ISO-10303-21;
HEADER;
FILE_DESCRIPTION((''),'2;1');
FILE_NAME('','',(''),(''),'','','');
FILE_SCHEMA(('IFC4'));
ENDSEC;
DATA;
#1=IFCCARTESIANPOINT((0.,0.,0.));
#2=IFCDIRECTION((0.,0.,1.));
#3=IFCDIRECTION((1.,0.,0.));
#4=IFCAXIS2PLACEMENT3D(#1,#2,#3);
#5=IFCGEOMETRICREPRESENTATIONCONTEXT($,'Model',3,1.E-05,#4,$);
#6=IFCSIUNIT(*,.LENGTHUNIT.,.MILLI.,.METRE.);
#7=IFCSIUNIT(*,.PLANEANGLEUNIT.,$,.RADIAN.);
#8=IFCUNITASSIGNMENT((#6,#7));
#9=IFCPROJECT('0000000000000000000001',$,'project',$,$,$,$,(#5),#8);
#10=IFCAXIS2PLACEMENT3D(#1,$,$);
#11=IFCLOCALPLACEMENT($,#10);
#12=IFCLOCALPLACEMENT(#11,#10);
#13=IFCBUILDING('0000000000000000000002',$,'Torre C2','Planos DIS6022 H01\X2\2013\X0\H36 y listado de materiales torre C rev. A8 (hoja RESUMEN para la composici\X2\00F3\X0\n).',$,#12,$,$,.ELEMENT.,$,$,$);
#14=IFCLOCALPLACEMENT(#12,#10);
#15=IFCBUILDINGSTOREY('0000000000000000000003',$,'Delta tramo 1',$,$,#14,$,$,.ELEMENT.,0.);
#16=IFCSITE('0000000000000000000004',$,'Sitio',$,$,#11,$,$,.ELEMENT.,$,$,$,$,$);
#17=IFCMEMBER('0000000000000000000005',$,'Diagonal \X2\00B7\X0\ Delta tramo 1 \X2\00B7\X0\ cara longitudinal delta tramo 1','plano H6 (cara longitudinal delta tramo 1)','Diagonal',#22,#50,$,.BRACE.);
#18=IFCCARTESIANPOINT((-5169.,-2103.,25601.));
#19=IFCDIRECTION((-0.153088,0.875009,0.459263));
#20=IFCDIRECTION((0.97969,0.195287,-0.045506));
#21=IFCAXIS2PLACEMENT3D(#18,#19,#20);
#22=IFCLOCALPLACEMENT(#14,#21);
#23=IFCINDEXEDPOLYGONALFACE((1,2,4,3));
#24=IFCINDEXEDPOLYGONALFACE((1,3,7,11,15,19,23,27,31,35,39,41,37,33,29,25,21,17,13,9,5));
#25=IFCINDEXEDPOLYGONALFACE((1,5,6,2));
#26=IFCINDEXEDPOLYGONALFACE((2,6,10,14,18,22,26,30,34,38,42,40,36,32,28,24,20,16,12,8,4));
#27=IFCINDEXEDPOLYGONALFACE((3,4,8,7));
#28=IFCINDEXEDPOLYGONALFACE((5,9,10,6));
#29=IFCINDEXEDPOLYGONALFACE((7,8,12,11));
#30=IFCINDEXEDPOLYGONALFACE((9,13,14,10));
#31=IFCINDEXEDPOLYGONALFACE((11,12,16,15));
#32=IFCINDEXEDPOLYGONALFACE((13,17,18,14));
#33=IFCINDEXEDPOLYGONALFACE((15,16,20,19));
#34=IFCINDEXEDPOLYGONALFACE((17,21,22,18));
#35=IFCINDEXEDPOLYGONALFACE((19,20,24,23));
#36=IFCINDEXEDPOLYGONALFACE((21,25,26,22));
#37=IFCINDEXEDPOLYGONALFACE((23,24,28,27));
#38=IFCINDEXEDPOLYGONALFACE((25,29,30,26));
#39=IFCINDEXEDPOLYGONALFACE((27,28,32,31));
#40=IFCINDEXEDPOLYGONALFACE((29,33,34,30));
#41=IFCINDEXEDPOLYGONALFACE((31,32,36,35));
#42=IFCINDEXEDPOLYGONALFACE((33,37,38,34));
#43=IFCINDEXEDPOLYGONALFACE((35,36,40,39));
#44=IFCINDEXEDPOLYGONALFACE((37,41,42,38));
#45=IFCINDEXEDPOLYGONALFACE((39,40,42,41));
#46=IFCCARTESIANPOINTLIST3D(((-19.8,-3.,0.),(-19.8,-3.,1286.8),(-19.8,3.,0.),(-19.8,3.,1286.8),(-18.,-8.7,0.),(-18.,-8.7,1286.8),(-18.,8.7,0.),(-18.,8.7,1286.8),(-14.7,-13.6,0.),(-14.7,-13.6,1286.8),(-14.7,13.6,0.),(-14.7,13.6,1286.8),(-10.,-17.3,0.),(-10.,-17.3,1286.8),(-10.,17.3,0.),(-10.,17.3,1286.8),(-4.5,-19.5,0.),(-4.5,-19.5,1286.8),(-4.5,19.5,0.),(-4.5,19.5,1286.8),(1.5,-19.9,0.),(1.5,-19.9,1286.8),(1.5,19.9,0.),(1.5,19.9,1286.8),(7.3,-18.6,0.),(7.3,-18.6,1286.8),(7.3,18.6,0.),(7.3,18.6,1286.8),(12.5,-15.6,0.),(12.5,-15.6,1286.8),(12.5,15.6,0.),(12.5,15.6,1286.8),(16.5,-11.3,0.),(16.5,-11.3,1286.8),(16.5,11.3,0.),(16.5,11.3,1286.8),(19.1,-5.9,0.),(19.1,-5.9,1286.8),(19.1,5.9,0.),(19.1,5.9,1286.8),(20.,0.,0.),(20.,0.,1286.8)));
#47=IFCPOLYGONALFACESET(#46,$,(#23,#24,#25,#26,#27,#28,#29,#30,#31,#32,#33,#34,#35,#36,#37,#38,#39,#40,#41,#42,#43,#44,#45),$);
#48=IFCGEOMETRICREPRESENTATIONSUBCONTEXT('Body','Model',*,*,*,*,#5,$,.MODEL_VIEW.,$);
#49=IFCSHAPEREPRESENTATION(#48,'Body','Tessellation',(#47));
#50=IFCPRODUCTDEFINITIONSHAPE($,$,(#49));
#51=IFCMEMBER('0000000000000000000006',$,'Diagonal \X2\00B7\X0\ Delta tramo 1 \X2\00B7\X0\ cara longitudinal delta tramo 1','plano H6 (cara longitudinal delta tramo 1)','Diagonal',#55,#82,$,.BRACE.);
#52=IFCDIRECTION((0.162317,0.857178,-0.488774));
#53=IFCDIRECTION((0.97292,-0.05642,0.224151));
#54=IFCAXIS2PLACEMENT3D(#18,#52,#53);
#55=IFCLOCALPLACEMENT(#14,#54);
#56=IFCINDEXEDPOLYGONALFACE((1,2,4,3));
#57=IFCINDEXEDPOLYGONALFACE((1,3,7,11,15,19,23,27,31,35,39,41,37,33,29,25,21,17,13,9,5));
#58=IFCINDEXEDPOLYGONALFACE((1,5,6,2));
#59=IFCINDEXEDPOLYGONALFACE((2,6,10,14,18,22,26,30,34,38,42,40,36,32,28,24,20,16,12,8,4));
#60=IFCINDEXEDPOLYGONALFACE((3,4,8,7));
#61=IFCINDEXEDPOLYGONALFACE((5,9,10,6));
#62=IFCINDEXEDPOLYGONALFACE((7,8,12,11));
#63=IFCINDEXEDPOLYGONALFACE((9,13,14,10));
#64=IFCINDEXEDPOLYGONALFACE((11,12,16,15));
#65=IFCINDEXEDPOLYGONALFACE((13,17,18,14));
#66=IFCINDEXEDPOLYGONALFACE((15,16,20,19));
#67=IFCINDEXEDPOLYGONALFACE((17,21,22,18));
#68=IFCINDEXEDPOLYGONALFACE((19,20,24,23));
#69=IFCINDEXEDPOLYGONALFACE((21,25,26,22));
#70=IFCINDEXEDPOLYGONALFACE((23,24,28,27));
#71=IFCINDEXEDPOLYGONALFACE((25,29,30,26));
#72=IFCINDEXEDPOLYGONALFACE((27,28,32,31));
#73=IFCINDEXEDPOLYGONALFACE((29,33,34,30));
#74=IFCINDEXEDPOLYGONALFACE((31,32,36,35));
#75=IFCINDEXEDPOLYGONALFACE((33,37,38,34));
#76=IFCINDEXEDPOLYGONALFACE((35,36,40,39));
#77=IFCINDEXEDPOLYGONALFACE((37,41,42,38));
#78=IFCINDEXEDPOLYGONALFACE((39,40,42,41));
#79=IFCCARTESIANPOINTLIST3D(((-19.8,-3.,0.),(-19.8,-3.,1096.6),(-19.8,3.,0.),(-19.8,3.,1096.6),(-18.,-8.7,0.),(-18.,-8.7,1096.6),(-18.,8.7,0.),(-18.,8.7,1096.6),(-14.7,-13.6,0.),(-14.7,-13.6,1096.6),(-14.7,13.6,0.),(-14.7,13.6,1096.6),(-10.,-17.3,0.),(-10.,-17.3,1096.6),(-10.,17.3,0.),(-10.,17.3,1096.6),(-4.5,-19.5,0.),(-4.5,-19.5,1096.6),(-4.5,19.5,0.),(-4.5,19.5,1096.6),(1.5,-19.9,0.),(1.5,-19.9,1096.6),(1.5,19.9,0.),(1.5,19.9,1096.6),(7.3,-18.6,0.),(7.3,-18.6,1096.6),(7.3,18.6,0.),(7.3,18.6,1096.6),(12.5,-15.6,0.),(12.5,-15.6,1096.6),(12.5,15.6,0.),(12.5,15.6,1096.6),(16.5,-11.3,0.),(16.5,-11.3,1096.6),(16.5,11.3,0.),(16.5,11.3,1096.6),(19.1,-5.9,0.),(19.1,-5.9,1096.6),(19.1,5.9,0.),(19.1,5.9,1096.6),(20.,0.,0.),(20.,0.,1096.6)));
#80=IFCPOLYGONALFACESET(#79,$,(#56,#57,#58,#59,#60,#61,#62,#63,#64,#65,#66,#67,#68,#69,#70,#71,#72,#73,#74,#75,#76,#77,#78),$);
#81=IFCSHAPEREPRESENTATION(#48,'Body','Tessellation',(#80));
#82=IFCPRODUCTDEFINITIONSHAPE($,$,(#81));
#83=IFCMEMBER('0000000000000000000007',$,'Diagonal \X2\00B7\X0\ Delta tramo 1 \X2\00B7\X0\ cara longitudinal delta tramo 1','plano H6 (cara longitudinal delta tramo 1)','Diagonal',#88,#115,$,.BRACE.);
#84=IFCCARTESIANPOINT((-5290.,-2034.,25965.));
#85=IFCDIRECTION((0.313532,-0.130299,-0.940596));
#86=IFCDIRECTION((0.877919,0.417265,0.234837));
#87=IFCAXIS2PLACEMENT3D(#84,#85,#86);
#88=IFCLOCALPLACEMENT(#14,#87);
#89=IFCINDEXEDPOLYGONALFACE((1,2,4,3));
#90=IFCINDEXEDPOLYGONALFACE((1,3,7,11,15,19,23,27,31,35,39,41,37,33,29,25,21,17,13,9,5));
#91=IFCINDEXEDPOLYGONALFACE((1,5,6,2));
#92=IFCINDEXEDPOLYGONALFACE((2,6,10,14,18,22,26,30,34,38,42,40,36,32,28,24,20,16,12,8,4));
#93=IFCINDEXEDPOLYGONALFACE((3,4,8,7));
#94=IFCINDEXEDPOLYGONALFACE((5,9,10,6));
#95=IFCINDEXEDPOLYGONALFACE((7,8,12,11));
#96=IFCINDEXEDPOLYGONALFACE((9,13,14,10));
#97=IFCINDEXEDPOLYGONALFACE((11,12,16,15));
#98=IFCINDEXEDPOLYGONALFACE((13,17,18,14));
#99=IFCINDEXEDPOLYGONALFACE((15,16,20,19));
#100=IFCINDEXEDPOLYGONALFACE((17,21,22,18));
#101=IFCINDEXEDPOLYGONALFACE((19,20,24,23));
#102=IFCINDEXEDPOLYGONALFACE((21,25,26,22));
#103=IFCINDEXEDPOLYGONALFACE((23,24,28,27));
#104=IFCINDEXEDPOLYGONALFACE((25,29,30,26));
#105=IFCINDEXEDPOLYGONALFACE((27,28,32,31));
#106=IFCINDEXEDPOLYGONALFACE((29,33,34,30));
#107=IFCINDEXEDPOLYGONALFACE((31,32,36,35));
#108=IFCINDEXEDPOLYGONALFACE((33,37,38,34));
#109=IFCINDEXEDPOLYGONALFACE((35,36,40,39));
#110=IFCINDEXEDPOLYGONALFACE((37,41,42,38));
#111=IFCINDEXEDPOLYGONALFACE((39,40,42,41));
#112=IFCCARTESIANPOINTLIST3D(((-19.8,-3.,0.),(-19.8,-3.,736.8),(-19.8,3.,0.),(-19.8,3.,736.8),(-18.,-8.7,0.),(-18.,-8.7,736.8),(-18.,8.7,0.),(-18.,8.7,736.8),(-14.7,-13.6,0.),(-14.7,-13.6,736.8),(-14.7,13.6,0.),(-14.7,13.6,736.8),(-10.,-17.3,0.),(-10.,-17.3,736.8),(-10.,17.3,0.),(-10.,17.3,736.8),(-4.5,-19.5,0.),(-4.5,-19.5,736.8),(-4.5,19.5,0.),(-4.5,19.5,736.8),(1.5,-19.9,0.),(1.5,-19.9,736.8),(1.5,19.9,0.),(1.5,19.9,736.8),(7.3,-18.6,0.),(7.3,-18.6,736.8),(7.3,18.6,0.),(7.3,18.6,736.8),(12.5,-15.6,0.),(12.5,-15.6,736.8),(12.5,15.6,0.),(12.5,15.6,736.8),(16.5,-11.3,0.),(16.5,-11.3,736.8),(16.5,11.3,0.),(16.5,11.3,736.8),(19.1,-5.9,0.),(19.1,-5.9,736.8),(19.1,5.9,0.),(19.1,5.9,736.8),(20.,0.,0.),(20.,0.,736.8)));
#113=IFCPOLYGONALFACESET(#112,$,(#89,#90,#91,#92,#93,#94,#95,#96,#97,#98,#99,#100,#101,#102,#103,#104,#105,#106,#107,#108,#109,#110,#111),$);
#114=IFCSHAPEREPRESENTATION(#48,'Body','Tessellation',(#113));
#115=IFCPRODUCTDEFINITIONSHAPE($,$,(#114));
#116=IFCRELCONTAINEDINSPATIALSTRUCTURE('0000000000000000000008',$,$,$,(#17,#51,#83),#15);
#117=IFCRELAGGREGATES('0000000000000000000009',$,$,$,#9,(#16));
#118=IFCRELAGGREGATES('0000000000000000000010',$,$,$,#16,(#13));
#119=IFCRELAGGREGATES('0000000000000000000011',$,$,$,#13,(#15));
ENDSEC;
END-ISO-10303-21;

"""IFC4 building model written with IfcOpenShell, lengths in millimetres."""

from ifc_helpers import new_model, si_unit, frame, origin, origin_with_axes, place, context, subcontext, project, spatial, circle, extrude, element, save


model = new_model("IFC4")

# Units and contexts
model_context = context("Model", 3, precision=1e-05, world=origin_with_axes())
body_context = subcontext(model_context, "Body", "Model", "MODEL_VIEW")
ifc_project = project(units=[si_unit("LENGTHUNIT", "METRE", prefix="MILLI"), si_unit("PLANEANGLEUNIT", "RADIAN")], contexts=[model_context])

# Site, building, storey
site_placement = place(None, origin())
site = spatial("IfcSite", under=ifc_project, at=site_placement, Name="Sitio", CompositionType="ELEMENT")
building_placement = place(site_placement, origin())
building = spatial("IfcBuilding", under=site, at=building_placement, Name="Torre C2", Description="Planos DIS6022 H01–H36 y listado de materiales torre C rev. A8 (hoja RESUMEN para la composición).", CompositionType="ELEMENT")
storey_placement = place(building_placement, origin())
storey = spatial("IfcBuildingStorey", under=building, at=storey_placement, Name="Delta tramo 1", CompositionType="ELEMENT", Elevation=0.0)

# Members
member_1_placement = place(storey_placement, frame((-5169.0, -2103.0, 25601.0), z_axis=(-0.153088, 0.875009, 0.459263), x_axis=(0.97969, 0.195287, -0.045506)))
element("IfcMember", 1, at=member_1_placement, inside=storey, Name="Diagonal · Delta tramo 1 · cara longitudinal delta tramo 1", Description="plano H6 (cara longitudinal delta tramo 1)", ObjectType="Diagonal", PredefinedType="BRACE", context=body_context, shape_type="SweptSolid", body=[
    extrude(circle(Radius=20.0), None, (0.0, 0.0, 1.0), 1286.8),
])
member_2_placement = place(storey_placement, frame((-5169.0, -2103.0, 25601.0), z_axis=(0.162317, 0.857178, -0.488774), x_axis=(0.97292, -0.05642, 0.224151)))
element("IfcMember", 2, at=member_2_placement, inside=storey, Name="Diagonal · Delta tramo 1 · cara longitudinal delta tramo 1", Description="plano H6 (cara longitudinal delta tramo 1)", ObjectType="Diagonal", PredefinedType="BRACE", context=body_context, shape_type="SweptSolid", body=[
    extrude(circle(Radius=20.0), None, (0.0, 0.0, 1.0), 1096.6),
])
member_3_placement = place(storey_placement, frame((-5290.0, -2034.0, 25965.0), z_axis=(0.313532, -0.130299, -0.940596), x_axis=(0.877919, 0.417265, 0.234837)))
element("IfcMember", 3, at=member_3_placement, inside=storey, Name="Diagonal · Delta tramo 1 · cara longitudinal delta tramo 1", Description="plano H6 (cara longitudinal delta tramo 1)", ObjectType="Diagonal", PredefinedType="BRACE", context=body_context, shape_type="SweptSolid", body=[
    extrude(circle(Radius=20.0), None, (0.0, 0.0, 1.0), 736.8),
])

save(model, "model.ifc")
